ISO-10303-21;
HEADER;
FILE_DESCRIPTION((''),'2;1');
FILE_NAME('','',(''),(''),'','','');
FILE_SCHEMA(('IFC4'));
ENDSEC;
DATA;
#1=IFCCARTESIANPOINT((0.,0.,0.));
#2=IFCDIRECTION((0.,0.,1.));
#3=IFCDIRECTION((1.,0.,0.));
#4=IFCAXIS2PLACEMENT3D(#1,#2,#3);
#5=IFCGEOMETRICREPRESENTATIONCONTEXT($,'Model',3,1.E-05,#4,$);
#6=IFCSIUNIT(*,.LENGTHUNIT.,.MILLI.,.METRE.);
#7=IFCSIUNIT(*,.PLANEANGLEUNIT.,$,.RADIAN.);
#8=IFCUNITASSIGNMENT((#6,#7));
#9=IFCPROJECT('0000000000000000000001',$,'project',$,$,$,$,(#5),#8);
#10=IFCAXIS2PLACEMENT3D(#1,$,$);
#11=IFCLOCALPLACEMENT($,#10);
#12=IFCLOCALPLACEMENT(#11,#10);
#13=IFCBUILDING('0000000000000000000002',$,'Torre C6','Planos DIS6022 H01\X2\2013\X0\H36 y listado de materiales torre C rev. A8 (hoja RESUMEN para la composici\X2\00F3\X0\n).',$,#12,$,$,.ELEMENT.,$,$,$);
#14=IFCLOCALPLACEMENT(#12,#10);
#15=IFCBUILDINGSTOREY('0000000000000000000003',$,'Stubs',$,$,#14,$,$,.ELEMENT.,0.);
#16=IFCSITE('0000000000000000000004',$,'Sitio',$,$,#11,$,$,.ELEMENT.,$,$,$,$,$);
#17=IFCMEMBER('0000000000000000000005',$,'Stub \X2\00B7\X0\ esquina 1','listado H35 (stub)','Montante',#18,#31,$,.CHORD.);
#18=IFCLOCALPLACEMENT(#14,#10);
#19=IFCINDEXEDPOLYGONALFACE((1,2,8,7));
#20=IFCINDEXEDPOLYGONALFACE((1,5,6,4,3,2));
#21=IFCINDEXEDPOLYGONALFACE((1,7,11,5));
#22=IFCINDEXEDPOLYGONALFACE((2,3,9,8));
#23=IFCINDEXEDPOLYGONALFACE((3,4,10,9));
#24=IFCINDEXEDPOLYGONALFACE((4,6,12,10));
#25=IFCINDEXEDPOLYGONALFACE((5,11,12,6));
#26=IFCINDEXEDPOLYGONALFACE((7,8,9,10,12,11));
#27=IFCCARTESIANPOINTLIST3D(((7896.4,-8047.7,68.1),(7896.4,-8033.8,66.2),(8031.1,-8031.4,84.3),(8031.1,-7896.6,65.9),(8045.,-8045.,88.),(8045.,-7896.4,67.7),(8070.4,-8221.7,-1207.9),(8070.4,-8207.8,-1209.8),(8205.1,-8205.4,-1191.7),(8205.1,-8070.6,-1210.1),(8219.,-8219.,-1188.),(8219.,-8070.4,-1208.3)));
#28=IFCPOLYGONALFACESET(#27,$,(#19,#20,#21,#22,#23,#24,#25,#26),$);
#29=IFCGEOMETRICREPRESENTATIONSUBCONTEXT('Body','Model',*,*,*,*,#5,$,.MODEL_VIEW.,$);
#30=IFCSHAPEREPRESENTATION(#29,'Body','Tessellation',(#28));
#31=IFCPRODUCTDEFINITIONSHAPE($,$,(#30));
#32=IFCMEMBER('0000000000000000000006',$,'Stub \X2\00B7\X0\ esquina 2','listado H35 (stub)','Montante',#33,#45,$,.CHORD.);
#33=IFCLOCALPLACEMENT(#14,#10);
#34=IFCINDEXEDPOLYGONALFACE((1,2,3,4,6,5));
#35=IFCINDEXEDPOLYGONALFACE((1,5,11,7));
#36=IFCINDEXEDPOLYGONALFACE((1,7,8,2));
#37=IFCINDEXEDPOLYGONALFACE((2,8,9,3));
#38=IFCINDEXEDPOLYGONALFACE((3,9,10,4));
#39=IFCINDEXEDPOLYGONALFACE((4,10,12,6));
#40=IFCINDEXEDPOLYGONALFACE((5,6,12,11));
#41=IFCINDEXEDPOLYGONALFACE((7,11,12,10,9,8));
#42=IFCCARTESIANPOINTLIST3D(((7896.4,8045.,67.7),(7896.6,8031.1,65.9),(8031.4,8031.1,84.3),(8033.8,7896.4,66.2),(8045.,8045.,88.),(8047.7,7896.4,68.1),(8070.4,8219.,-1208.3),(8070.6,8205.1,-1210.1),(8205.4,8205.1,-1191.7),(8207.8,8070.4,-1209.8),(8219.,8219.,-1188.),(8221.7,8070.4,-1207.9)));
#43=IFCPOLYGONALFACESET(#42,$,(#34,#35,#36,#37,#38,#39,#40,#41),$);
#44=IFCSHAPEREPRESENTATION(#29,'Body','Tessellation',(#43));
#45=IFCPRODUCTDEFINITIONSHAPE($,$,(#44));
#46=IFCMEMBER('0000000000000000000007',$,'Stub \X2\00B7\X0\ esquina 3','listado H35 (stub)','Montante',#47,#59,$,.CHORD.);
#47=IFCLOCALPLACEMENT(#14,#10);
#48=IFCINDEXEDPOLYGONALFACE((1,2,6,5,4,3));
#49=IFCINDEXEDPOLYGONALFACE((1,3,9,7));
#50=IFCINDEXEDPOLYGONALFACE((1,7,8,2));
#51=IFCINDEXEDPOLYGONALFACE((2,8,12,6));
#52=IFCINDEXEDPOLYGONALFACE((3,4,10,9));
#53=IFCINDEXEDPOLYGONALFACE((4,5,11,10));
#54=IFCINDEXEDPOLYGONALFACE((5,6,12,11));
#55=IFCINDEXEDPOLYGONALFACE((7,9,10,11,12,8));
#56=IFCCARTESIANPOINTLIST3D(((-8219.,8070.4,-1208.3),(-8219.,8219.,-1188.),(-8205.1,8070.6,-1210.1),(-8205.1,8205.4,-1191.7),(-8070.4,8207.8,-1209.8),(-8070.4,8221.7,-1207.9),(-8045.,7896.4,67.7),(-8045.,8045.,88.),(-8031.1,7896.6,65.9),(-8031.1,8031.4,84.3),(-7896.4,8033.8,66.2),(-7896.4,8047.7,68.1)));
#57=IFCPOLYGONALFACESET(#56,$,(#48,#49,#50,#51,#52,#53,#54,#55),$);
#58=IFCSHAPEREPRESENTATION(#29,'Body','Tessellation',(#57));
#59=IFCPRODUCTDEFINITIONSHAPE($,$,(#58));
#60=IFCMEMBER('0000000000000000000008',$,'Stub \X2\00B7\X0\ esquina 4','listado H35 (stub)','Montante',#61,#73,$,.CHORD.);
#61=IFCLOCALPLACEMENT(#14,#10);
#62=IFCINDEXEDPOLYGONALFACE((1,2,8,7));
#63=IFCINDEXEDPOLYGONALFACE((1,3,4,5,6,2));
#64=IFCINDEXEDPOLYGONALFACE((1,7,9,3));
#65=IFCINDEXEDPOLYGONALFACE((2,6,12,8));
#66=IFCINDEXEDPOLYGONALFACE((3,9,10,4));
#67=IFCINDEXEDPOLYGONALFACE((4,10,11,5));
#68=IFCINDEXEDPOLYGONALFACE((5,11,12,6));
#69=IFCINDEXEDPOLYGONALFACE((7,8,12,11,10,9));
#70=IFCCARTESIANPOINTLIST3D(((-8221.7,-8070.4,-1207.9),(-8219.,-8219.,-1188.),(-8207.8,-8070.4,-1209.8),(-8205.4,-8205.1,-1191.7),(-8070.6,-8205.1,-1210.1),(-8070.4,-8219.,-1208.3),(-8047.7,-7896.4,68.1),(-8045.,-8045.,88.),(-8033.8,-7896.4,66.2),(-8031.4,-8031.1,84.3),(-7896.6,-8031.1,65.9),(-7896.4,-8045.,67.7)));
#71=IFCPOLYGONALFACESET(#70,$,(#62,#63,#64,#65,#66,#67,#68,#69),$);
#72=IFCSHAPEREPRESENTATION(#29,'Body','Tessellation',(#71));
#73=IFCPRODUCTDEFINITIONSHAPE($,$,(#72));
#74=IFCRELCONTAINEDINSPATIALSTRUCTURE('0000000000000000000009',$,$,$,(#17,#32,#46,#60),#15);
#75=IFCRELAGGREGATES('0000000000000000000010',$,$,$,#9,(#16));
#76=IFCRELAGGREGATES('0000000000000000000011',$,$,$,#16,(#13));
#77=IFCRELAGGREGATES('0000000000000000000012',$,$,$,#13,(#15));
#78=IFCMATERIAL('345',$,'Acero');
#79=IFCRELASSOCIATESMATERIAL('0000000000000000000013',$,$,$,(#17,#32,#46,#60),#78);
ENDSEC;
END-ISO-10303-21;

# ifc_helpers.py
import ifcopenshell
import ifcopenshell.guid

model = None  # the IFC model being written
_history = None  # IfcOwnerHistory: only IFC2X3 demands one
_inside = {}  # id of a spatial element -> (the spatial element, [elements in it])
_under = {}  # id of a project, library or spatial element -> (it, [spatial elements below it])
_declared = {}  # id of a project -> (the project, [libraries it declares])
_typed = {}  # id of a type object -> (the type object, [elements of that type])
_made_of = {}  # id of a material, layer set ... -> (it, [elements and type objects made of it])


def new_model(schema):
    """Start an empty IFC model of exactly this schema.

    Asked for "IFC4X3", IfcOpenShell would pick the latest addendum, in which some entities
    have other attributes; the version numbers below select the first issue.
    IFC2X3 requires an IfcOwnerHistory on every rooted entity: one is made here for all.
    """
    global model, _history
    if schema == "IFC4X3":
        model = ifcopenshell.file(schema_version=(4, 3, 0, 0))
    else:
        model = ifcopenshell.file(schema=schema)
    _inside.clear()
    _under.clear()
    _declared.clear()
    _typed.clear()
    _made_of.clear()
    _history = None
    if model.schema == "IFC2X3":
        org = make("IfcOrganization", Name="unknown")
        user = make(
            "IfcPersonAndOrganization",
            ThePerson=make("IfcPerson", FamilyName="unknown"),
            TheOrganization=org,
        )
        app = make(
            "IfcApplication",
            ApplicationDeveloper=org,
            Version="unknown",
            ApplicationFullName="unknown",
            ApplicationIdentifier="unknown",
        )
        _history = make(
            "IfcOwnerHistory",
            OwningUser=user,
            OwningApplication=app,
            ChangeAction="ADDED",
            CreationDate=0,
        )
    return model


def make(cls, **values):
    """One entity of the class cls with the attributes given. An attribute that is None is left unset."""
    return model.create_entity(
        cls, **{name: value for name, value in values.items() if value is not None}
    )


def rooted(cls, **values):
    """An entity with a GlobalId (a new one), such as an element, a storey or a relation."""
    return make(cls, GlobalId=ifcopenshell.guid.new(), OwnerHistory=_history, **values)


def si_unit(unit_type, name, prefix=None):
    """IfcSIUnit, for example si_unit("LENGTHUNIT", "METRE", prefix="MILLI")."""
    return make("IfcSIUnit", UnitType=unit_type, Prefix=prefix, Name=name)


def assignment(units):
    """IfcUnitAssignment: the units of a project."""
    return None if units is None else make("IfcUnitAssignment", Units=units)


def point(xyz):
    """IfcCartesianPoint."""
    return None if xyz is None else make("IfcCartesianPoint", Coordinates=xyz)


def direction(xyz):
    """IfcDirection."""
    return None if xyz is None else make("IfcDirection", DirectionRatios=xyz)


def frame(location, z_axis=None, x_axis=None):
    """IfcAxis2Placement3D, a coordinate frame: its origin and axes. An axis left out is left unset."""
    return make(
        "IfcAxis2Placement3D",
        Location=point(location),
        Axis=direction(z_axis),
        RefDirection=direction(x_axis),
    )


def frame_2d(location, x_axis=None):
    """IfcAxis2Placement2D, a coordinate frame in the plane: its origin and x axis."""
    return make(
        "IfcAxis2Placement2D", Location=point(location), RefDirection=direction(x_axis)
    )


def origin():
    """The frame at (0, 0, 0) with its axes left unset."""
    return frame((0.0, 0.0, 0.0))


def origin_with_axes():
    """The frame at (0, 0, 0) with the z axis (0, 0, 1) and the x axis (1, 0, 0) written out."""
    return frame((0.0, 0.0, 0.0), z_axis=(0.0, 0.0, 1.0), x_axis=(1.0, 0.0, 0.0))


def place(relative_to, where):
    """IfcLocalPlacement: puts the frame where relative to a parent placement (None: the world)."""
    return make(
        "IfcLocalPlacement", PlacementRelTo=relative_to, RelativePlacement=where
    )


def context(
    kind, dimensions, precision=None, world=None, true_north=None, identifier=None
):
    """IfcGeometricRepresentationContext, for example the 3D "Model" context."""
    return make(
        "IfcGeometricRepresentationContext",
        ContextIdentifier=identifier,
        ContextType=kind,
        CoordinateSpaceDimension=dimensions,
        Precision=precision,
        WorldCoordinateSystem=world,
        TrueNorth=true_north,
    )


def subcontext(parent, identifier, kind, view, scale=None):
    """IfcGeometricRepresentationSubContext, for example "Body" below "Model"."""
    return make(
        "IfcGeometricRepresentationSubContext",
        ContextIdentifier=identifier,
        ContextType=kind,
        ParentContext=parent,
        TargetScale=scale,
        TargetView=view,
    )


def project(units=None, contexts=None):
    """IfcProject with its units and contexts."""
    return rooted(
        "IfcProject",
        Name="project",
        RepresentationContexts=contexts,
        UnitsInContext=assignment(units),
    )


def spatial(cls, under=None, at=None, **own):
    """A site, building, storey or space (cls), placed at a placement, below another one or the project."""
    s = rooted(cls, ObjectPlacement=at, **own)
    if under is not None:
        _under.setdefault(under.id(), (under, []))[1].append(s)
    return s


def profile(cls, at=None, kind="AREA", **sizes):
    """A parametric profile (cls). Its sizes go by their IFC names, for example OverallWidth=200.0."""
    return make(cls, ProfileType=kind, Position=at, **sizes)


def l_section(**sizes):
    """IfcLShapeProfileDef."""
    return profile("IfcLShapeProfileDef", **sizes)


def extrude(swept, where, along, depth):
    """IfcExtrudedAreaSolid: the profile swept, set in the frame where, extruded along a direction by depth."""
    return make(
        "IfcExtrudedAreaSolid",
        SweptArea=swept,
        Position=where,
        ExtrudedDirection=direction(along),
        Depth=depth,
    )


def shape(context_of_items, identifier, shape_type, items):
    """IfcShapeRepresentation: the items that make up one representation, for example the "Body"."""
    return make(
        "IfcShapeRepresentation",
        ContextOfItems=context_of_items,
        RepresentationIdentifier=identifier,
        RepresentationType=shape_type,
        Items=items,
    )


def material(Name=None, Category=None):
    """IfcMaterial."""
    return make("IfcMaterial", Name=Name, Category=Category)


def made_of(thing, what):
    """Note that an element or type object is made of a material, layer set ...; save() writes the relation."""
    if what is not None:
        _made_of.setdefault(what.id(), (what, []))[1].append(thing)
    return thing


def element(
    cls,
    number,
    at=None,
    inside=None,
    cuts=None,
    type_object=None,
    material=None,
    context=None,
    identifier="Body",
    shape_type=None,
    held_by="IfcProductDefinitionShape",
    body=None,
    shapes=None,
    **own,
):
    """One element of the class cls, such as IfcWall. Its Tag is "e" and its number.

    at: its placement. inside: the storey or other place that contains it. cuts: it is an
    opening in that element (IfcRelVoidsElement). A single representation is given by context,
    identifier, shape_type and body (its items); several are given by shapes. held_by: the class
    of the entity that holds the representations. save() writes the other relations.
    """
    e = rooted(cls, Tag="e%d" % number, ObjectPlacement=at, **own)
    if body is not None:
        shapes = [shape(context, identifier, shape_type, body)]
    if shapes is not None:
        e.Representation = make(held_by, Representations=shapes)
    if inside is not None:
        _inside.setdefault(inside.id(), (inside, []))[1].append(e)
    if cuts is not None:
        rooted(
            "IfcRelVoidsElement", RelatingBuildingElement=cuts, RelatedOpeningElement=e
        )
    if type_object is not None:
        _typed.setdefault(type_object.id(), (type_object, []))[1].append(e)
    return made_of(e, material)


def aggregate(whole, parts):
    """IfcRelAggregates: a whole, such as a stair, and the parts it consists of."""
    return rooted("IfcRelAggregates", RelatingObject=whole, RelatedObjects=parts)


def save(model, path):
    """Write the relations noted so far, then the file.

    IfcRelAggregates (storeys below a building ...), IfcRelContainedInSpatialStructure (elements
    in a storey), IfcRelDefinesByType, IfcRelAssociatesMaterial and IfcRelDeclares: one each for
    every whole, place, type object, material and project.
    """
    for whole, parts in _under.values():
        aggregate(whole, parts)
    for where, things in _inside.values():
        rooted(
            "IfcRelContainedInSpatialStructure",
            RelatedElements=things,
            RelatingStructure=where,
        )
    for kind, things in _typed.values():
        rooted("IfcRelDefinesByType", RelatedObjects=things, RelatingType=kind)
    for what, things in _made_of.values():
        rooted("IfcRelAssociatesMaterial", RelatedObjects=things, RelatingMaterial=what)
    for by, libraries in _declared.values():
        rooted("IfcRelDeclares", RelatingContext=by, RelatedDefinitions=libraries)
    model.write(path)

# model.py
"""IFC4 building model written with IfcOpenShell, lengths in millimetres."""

from ifc_helpers import new_model, si_unit, frame, frame_2d, origin, origin_with_axes, place, context, subcontext, project, spatial, l_section, extrude, material, element, save


model = new_model("IFC4")

# Units and contexts
model_context = context("Model", 3, precision=1e-05, world=origin_with_axes())
body_context = subcontext(model_context, "Body", "Model", "MODEL_VIEW")
ifc_project = project(units=[si_unit("LENGTHUNIT", "METRE", prefix="MILLI"), si_unit("PLANEANGLEUNIT", "RADIAN")], contexts=[model_context])

# Site, building, storey
site_placement = place(None, origin())
site = spatial("IfcSite", under=ifc_project, at=site_placement, Name="Sitio", CompositionType="ELEMENT")
building_placement = place(site_placement, origin())
building = spatial("IfcBuilding", under=site, at=building_placement, Name="Torre C6", Description="Planos DIS6022 H01–H36 y listado de materiales torre C rev. A8 (hoja RESUMEN para la composición).", CompositionType="ELEMENT")
storey_placement = place(building_placement, origin())
storey = spatial("IfcBuildingStorey", under=building, at=storey_placement, Name="Stubs", CompositionType="ELEMENT", Elevation=0.0)

# Members
ifc_material = material(Name="345", Category="Acero")
for number, where, z_axis, x_axis, name in (
    (1, (8045.0, -8045.0, 88.0), (0.133897, -0.133897, -0.981908), (-0.990995, -0.018091, -0.132669), "Stub · esquina 1"),
    (2, (8045.0, 8045.0, 88.0), (0.133897, 0.133897, -0.981908), (0.018091, -0.990995, -0.132669), "Stub · esquina 2"),
    (3, (-8045.0, 8045.0, 88.0), (-0.133897, 0.133897, -0.981908), (0.990995, 0.018091, -0.132669), "Stub · esquina 3"),
    (4, (-8045.0, -8045.0, 88.0), (-0.133897, -0.133897, -0.981908), (-0.018091, 0.990995, -0.132669), "Stub · esquina 4"),
):
    element("IfcMember", number, at=place(storey_placement, frame(where, z_axis=z_axis, x_axis=x_axis)), inside=storey, material=ifc_material, Name=name, Description="listado H35 (stub)", ObjectType="Montante", PredefinedType="CHORD", context=body_context, shape_type="SweptSolid", body=[
        extrude(l_section(Depth=150.0, Width=150.0, Thickness=14.0, at=frame_2d((75.0, 75.0))), None, (0.0, 0.0, 1.0), 1299.5),
    ])

save(model, "model.ifc")
